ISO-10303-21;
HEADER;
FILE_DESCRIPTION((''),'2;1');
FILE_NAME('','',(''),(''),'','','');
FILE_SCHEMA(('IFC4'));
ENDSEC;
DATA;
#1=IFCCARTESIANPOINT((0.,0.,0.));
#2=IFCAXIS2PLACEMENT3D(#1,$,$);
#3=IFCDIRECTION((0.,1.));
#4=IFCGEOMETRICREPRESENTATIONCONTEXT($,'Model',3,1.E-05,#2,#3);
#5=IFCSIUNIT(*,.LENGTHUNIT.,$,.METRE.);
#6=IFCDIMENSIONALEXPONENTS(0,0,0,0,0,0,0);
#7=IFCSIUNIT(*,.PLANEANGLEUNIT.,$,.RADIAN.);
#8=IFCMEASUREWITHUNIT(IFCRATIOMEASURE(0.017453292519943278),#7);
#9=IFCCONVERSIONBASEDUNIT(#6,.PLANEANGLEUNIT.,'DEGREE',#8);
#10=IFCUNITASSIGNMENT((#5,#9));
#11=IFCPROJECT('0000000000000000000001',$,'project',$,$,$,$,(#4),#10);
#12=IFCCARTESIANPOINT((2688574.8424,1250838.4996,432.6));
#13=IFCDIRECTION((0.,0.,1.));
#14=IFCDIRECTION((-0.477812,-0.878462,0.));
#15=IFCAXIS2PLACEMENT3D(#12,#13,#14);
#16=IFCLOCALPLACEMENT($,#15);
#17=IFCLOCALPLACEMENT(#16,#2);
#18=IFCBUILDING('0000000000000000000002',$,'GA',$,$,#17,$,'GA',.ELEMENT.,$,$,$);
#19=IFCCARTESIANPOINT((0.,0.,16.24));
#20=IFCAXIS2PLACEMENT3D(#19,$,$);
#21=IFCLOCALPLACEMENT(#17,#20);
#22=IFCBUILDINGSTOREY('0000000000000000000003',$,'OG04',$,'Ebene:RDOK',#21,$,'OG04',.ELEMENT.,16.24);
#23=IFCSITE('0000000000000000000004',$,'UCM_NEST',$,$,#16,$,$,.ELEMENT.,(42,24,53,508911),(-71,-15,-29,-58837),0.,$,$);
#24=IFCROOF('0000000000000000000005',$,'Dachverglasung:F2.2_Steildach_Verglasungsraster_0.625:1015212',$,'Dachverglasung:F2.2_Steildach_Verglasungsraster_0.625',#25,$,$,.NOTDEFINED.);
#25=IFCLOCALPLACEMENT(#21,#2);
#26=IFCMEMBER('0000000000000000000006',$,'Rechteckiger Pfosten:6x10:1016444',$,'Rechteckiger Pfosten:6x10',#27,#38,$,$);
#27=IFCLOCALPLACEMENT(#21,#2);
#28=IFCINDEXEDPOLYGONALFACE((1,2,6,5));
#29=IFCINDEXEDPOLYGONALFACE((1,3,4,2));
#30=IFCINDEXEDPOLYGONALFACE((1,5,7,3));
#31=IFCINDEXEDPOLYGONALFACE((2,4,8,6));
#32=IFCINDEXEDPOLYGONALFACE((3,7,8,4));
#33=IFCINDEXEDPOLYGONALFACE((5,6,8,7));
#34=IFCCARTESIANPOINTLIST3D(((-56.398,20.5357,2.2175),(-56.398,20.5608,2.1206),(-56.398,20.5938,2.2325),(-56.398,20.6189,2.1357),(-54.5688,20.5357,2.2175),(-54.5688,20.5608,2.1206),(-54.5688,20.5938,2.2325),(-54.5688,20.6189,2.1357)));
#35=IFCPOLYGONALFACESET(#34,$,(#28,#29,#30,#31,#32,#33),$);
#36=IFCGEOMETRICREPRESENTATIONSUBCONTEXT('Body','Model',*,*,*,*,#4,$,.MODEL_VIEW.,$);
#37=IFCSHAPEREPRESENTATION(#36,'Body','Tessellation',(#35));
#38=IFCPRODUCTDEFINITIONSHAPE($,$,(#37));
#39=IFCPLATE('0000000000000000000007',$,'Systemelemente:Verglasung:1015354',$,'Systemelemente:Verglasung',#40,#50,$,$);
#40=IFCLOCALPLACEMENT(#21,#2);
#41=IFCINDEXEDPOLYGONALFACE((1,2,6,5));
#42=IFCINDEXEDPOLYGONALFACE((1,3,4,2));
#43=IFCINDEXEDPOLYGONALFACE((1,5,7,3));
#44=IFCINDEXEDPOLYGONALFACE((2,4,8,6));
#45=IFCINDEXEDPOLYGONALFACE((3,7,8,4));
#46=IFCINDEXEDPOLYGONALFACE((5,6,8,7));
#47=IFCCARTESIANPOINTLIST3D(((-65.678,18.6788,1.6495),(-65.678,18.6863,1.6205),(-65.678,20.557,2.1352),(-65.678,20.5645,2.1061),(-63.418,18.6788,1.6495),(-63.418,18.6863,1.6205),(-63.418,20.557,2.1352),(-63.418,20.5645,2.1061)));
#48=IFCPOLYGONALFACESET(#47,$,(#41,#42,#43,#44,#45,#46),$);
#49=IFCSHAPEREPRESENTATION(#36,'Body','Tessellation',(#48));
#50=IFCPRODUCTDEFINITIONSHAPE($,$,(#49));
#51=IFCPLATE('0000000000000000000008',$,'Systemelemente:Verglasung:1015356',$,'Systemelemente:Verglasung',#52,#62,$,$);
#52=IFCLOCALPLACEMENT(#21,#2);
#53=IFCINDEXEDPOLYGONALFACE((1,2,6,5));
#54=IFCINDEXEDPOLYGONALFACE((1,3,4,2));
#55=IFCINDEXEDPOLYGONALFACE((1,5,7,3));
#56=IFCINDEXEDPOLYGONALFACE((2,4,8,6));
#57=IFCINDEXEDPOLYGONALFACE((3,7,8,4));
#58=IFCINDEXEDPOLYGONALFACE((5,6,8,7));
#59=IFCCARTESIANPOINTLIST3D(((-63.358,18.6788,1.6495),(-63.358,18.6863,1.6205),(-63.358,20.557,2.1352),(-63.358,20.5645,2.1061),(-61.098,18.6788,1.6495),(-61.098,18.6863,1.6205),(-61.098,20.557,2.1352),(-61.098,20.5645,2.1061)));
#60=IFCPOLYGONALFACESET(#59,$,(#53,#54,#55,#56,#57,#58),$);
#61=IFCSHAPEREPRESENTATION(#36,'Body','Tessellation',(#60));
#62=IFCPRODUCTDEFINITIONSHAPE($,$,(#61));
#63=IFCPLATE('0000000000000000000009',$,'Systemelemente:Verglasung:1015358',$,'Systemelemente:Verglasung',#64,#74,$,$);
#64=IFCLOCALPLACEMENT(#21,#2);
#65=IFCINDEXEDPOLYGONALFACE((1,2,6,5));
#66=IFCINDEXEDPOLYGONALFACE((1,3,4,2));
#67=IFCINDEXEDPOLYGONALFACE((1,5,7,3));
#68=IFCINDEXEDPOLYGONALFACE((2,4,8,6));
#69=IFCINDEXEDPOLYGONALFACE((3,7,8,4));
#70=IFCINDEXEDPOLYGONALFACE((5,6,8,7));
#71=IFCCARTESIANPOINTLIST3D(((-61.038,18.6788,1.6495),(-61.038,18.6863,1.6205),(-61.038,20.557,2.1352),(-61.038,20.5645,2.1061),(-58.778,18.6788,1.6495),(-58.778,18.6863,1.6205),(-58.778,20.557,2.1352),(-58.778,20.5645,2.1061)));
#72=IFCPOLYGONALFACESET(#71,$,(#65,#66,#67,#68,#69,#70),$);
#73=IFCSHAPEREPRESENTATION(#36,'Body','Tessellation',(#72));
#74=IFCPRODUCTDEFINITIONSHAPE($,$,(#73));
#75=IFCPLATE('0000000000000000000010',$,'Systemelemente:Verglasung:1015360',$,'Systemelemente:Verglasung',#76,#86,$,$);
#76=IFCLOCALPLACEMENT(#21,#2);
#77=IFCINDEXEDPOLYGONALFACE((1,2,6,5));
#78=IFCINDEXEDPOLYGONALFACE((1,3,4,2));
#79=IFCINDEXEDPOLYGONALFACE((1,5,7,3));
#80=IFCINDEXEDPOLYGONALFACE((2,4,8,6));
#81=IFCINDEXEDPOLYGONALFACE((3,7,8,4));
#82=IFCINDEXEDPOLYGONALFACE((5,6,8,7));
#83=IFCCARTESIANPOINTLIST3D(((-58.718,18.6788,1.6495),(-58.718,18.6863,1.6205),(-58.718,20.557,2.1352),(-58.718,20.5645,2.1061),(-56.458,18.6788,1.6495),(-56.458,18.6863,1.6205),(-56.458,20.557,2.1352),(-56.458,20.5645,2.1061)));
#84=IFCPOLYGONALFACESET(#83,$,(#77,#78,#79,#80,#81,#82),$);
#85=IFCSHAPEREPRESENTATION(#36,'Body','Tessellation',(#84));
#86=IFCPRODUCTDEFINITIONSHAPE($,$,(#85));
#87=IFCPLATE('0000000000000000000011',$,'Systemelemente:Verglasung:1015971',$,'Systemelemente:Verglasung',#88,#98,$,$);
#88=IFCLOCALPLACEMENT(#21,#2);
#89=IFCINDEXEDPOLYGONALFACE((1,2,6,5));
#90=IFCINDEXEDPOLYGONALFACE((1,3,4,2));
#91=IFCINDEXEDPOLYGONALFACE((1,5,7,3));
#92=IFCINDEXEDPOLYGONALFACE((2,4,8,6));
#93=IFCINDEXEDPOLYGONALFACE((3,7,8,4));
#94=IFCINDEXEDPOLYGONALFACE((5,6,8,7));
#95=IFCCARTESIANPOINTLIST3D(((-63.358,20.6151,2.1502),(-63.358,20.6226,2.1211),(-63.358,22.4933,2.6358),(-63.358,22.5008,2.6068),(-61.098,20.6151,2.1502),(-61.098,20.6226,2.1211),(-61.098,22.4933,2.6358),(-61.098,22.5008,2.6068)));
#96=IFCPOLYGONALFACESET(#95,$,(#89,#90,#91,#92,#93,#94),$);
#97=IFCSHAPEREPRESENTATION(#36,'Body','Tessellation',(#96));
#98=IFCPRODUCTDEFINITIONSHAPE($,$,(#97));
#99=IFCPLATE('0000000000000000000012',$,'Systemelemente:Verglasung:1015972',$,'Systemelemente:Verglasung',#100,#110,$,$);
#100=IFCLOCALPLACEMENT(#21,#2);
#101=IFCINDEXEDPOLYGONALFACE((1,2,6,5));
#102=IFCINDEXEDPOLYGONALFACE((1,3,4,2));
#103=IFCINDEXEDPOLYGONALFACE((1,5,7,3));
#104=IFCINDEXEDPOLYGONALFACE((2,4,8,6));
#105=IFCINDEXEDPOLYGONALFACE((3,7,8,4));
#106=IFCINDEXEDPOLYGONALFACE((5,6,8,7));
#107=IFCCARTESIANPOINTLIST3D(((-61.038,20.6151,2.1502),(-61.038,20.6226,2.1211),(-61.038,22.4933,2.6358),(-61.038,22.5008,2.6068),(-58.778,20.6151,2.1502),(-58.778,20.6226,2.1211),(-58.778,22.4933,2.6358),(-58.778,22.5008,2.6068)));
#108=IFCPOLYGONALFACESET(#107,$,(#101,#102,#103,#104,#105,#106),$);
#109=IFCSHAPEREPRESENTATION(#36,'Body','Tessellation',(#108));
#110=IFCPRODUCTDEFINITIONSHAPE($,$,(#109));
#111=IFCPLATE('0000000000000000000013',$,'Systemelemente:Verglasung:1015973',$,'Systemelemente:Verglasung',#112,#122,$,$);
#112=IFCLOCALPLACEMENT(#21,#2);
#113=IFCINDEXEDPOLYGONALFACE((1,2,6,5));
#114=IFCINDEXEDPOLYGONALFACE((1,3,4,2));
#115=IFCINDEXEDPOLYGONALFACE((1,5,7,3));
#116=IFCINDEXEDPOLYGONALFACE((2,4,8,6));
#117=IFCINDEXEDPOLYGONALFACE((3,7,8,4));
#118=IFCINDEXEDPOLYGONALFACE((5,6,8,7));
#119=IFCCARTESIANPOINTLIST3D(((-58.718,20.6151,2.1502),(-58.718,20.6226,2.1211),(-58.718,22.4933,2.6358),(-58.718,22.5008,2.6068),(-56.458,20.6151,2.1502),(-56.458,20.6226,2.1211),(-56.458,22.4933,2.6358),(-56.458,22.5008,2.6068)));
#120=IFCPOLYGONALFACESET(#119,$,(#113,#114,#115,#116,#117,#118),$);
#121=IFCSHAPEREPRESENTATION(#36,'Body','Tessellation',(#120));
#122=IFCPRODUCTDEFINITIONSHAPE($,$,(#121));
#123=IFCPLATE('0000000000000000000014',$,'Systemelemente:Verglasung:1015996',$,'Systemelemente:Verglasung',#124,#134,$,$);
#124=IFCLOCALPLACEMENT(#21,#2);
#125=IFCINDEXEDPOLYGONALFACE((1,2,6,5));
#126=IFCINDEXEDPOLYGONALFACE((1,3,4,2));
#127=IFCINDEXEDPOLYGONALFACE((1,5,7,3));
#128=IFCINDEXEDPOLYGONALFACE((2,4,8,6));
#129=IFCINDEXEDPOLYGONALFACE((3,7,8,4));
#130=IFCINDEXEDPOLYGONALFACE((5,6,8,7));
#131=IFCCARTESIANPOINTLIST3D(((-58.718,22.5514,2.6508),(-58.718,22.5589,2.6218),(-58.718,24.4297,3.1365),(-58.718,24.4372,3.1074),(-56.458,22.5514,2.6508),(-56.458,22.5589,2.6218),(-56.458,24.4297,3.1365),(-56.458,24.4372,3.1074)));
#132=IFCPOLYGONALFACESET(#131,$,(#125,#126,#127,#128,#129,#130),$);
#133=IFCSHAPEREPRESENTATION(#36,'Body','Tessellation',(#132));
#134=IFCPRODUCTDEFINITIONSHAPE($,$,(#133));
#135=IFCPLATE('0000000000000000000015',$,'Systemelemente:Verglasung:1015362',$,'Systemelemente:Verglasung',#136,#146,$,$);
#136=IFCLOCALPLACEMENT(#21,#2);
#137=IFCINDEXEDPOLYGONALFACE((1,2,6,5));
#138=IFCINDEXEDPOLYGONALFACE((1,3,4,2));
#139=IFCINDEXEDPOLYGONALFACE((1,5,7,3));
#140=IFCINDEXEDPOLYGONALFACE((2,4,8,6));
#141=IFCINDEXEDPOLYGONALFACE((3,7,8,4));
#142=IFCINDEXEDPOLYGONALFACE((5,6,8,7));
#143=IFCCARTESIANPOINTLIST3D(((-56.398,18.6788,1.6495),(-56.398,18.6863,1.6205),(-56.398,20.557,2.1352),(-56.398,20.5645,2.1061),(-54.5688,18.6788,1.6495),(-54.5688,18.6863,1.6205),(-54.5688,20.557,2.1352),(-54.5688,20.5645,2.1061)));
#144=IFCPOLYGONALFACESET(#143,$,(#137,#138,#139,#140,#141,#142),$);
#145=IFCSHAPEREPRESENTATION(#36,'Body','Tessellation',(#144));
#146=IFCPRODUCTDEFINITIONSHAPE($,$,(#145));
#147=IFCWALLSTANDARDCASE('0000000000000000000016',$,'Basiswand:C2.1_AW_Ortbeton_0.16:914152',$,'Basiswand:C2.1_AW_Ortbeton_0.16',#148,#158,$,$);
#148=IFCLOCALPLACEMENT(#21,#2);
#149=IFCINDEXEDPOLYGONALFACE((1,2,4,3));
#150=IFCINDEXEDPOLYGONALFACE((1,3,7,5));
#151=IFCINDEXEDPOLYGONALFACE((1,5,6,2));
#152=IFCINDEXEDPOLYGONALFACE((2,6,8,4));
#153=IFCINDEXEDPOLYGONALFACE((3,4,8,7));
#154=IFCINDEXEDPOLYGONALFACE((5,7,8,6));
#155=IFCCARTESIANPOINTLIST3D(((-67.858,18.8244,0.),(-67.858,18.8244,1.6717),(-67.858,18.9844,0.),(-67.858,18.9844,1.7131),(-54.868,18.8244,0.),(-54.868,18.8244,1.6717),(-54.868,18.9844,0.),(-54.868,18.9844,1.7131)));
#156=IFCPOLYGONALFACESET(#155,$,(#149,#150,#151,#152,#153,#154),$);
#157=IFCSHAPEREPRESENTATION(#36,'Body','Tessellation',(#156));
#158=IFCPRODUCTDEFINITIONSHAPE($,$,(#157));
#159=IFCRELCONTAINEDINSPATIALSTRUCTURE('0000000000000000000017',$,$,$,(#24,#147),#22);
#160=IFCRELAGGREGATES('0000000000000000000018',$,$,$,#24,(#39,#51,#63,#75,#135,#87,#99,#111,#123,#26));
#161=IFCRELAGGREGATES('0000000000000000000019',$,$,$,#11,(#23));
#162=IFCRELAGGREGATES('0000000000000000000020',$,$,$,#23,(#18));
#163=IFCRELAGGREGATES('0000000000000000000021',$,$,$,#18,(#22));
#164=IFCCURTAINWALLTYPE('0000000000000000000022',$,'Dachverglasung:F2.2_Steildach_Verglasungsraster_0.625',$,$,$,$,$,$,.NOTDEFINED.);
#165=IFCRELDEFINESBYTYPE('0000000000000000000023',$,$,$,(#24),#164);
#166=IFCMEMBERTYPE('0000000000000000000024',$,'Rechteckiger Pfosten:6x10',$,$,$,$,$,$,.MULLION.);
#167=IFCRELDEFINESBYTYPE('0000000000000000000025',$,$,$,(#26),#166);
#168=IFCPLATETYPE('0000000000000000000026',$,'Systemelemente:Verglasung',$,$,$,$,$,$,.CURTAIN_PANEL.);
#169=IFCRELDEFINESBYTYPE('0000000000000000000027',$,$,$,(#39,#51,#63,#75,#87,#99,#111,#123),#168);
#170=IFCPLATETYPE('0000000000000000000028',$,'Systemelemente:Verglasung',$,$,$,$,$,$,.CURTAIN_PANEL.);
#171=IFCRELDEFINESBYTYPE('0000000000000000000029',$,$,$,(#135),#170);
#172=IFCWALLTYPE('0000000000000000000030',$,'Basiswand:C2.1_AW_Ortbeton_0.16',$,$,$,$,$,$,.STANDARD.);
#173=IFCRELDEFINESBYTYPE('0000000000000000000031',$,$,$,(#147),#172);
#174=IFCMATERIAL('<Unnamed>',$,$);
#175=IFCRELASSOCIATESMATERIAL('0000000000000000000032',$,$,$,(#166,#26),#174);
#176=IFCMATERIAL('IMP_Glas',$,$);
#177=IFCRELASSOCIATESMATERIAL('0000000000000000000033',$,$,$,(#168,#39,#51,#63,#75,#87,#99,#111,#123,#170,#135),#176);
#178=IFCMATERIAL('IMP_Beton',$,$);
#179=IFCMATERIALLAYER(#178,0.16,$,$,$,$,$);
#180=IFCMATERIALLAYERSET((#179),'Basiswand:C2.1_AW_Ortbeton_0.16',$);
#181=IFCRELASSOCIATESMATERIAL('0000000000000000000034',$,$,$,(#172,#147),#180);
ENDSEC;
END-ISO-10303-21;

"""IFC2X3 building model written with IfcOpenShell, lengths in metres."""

from ifc_helpers import new_model, entity, si_unit, converted_unit, direction, frame, frame_2d, origin, origin_2d_with_axis, place, context, subcontext, project, spatial, polyline, rectangle, extrude, clip, bounded_halfspace, source, transform, mapped, material, layer, layer_set, layer_usage, type_object, type_shapes, element, aggregate, save


model = new_model("IFC2X3")

# Units and contexts
model_context = context("Model", 3, precision=1e-05, world=origin(), true_north=direction((0.0, 1.0)))
body_context = subcontext(model_context, "Body", "Model", "MODEL_VIEW")
ifc_project = project(units=[si_unit("LENGTHUNIT", "METRE"), converted_unit("PLANEANGLEUNIT", "DEGREE", entity("IfcRatioMeasure", 0.017453292519943278), si_unit("PLANEANGLEUNIT", "RADIAN"), dimensions=[0, 0, 0, 0, 0, 0, 0])], contexts=[model_context])

# Site, building, storey
site_placement = place(None, frame((2688574.8424, 1250838.4996, 432.6), z_axis=(0.0, 0.0, 1.0), x_axis=(-0.477812, -0.878462, 0.0)))
site = spatial("IfcSite", under=ifc_project, at=site_placement, Name="UCM_NEST", CompositionType="ELEMENT", RefLatitude=(42, 24, 53, 508911), RefLongitude=(-71, -15, -29, -58837), RefElevation=0.0)
building_placement = place(site_placement, origin())
building = spatial("IfcBuilding", under=site, at=building_placement, Name="GA", LongName="GA", CompositionType="ELEMENT")
storey_placement = place(building_placement, frame((0.0, 0.0, 16.24)))
storey = spatial("IfcBuildingStorey", under=building, at=storey_placement, Name="OG04", ObjectType="Ebene:RDOK", LongName="OG04", CompositionType="ELEMENT", Elevation=16.24)

# Roof, member, plates
curtain_wall_type = type_object("IfcCurtainWallType", Name="Dachverglasung:F2.2_Steildach_Verglasungsraster_0.625", PredefinedType="NOTDEFINED")
roof_placement = place(storey_placement, frame((0.0, 0.0, -16.24)))
roof = element("IfcRoof", 1, at=roof_placement, inside=storey, type_object=curtain_wall_type, Name="Dachverglasung:F2.2_Steildach_Verglasungsraster_0.625:1015212", ObjectType="Dachverglasung:F2.2_Steildach_Verglasungsraster_0.625", ShapeType="NOTDEFINED")
ifc_material_1 = material(Name="<Unnamed>")
member_type_1 = type_object("IfcMemberType", Name="Rechteckiger Pfosten:6x10", PredefinedType="MULLION", material=ifc_material_1)
shared_shape_1 = source(origin(), body_context, "Body", "SweptSolid", [
    extrude(rectangle(XDim=0.1, YDim=0.06, at=origin_2d_with_axis()), frame((-0.03, -0.05, -1.8292), z_axis=(0.0, 0.0, 1.0), x_axis=(0.0, -1.0, 0.0)), (0.0, 0.0, 1.0), 1.8292),
])
type_shapes(member_type_1, [shared_shape_1])
member_1_placement = place(roof_placement, frame((-56.398, 20.6189, 18.3757), z_axis=(-1.0, 0.0, 0.0), x_axis=(0.0, 0.968163, 0.250322)))
member_1 = element("IfcMember", 2, at=member_1_placement, type_object=member_type_1, material=ifc_material_1, Name="Rechteckiger Pfosten:6x10:1016444", ObjectType="Rechteckiger Pfosten:6x10", context=body_context, shape_type="MappedRepresentation", body=[
    mapped(shared_shape_1, transform((0.0, 0.0, 0.0), scale=1.0)),
])
ifc_material_2 = material(Name="IMP_Glas")
plate_type_1 = type_object("IfcPlateType", Name="Systemelemente:Verglasung", PredefinedType="CURTAIN_PANEL", material=ifc_material_2)
shared_shape_2 = source(origin(), body_context, "Body", "SweptSolid", [
    extrude(rectangle(XDim=0.03, YDim=2.26, at=origin_2d_with_axis()), frame((0.0, 0.0, 0.0), z_axis=(0.0, 0.0, 1.0), x_axis=(0.0, 1.0, 0.0)), (0.0, 0.0, 1.0), 1.94),
])
type_shapes(plate_type_1, [shared_shape_2])
plate_1_placement = place(roof_placement, frame((-64.548, 18.6825, 17.875), z_axis=(0.0, 0.968163, 0.250322), x_axis=(1.0, 0.0, 0.0)))
plate_1 = element("IfcPlate", 3, at=plate_1_placement, type_object=plate_type_1, material=ifc_material_2, Name="Systemelemente:Verglasung:1015354", ObjectType="Systemelemente:Verglasung", context=body_context, shape_type="MappedRepresentation", body=[
    mapped(shared_shape_2, transform((0.0, 0.0, 0.0), scale=1.0)),
])
plate_2_placement = place(roof_placement, frame((-62.228, 18.6825, 17.875), z_axis=(0.0, 0.968163, 0.250322), x_axis=(1.0, 0.0, 0.0)))
plate_2 = element("IfcPlate", 4, at=plate_2_placement, type_object=plate_type_1, material=ifc_material_2, Name="Systemelemente:Verglasung:1015356", ObjectType="Systemelemente:Verglasung", context=body_context, shape_type="MappedRepresentation", body=[
    mapped(shared_shape_2, transform((0.0, 0.0, 0.0), scale=1.0)),
])
plate_3_placement = place(roof_placement, frame((-59.908, 18.6825, 17.875), z_axis=(0.0, 0.968163, 0.250322), x_axis=(1.0, 0.0, 0.0)))
plate_3 = element("IfcPlate", 5, at=plate_3_placement, type_object=plate_type_1, material=ifc_material_2, Name="Systemelemente:Verglasung:1015358", ObjectType="Systemelemente:Verglasung", context=body_context, shape_type="MappedRepresentation", body=[
    mapped(shared_shape_2, transform((0.0, 0.0, 0.0), scale=1.0)),
])
plate_4_placement = place(roof_placement, frame((-57.588, 18.6825, 17.875), z_axis=(0.0, 0.968163, 0.250322), x_axis=(1.0, 0.0, 0.0)))
plate_4 = element("IfcPlate", 6, at=plate_4_placement, type_object=plate_type_1, material=ifc_material_2, Name="Systemelemente:Verglasung:1015360", ObjectType="Systemelemente:Verglasung", context=body_context, shape_type="MappedRepresentation", body=[
    mapped(shared_shape_2, transform((0.0, 0.0, 0.0), scale=1.0)),
])
plate_5_placement = place(roof_placement, frame((-62.228, 20.6189, 18.3757), z_axis=(0.0, 0.968163, 0.250322), x_axis=(1.0, 0.0, 0.0)))
plate_5 = element("IfcPlate", 7, at=plate_5_placement, type_object=plate_type_1, material=ifc_material_2, Name="Systemelemente:Verglasung:1015971", ObjectType="Systemelemente:Verglasung", context=body_context, shape_type="MappedRepresentation", body=[
    mapped(shared_shape_2, transform((0.0, 0.0, 0.0), scale=1.0)),
])
plate_6_placement = place(roof_placement, frame((-59.908, 20.6189, 18.3757), z_axis=(0.0, 0.968163, 0.250322), x_axis=(1.0, 0.0, 0.0)))
plate_6 = element("IfcPlate", 8, at=plate_6_placement, type_object=plate_type_1, material=ifc_material_2, Name="Systemelemente:Verglasung:1015972", ObjectType="Systemelemente:Verglasung", context=body_context, shape_type="MappedRepresentation", body=[
    mapped(shared_shape_2, transform((0.0, 0.0, 0.0), scale=1.0)),
])
plate_7_placement = place(roof_placement, frame((-57.588, 20.6189, 18.3757), z_axis=(0.0, 0.968163, 0.250322), x_axis=(1.0, 0.0, 0.0)))
plate_7 = element("IfcPlate", 9, at=plate_7_placement, type_object=plate_type_1, material=ifc_material_2, Name="Systemelemente:Verglasung:1015973", ObjectType="Systemelemente:Verglasung", context=body_context, shape_type="MappedRepresentation", body=[
    mapped(shared_shape_2, transform((0.0, 0.0, 0.0), scale=1.0)),
])
plate_8_placement = place(roof_placement, frame((-57.588, 22.5552, 18.8763), z_axis=(0.0, 0.968163, 0.250322), x_axis=(1.0, 0.0, 0.0)))
plate_8 = element("IfcPlate", 10, at=plate_8_placement, type_object=plate_type_1, material=ifc_material_2, Name="Systemelemente:Verglasung:1015996", ObjectType="Systemelemente:Verglasung", context=body_context, shape_type="MappedRepresentation", body=[
    mapped(shared_shape_2, transform((0.0, 0.0, 0.0), scale=1.0)),
])
plate_type_2 = type_object("IfcPlateType", Name="Systemelemente:Verglasung", PredefinedType="CURTAIN_PANEL", material=ifc_material_2)
shared_shape_3 = source(origin(), body_context, "Body", "SweptSolid", [
    extrude(rectangle(XDim=0.03, YDim=1.8292, at=origin_2d_with_axis()), frame((0.0, 0.0, 0.0), z_axis=(0.0, 0.0, 1.0), x_axis=(0.0, 1.0, 0.0)), (0.0, 0.0, 1.0), 1.94),
])
type_shapes(plate_type_2, [shared_shape_3])
plate_9_placement = place(roof_placement, frame((-55.4834, 18.6825, 17.875), z_axis=(0.0, 0.968163, 0.250322), x_axis=(1.0, 0.0, 0.0)))
plate_9 = element("IfcPlate", 11, at=plate_9_placement, type_object=plate_type_2, material=ifc_material_2, Name="Systemelemente:Verglasung:1015362", ObjectType="Systemelemente:Verglasung", context=body_context, shape_type="MappedRepresentation", body=[
    mapped(shared_shape_3, transform((0.0, 0.0, 0.0), scale=1.0)),
])
aggregate(roof, [plate_1, plate_2, plate_3, plate_4, plate_9, plate_5, plate_6, plate_7, plate_8, member_1])

# Wall
ifc_material_3 = material(Name="IMP_Beton")
ifc_layer = layer(ifc_material_3, 0.16)
ifc_layer_set = layer_set([ifc_layer], Name="Basiswand:C2.1_AW_Ortbeton_0.16")
ifc_layer_usage = layer_usage(ifc_layer_set, "AXIS2", "NEGATIVE", 0.08)
wall_type = type_object("IfcWallType", Name="Basiswand:C2.1_AW_Ortbeton_0.16", PredefinedType="STANDARD", material=ifc_layer_set)
wall_placement = place(storey_placement, frame((-54.868, 18.9044, 0.0), z_axis=(0.0, 0.0, 1.0), x_axis=(-1.0, 0.0, 0.0)))
element("IfcWallStandardCase", 12, at=wall_placement, inside=storey, type_object=wall_type, material=ifc_layer_usage, Name="Basiswand:C2.1_AW_Ortbeton_0.16:914152", ObjectType="Basiswand:C2.1_AW_Ortbeton_0.16", context=body_context, shape_type="Clipping", body=[
    clip(extrude(rectangle(XDim=12.99, YDim=0.16, at=frame_2d((6.495, 0.0), x_axis=(-1.0, 0.0))), origin(), (0.0, 0.0, 1.0), 1.7131), bounded_halfspace(frame((0.0, -0.08, 1.7131), z_axis=(0.0, 0.250322, 0.968163), x_axis=(-1.0, 0.0, 0.0)), False, frame((0.0, -0.08, 1.7131)), polyline([(0.0, 0.0), (12.99, 0.0), (12.99, 0.16), (0.0, 0.16), (0.0, 0.0)]))),
])

save(model, "model.ifc")
